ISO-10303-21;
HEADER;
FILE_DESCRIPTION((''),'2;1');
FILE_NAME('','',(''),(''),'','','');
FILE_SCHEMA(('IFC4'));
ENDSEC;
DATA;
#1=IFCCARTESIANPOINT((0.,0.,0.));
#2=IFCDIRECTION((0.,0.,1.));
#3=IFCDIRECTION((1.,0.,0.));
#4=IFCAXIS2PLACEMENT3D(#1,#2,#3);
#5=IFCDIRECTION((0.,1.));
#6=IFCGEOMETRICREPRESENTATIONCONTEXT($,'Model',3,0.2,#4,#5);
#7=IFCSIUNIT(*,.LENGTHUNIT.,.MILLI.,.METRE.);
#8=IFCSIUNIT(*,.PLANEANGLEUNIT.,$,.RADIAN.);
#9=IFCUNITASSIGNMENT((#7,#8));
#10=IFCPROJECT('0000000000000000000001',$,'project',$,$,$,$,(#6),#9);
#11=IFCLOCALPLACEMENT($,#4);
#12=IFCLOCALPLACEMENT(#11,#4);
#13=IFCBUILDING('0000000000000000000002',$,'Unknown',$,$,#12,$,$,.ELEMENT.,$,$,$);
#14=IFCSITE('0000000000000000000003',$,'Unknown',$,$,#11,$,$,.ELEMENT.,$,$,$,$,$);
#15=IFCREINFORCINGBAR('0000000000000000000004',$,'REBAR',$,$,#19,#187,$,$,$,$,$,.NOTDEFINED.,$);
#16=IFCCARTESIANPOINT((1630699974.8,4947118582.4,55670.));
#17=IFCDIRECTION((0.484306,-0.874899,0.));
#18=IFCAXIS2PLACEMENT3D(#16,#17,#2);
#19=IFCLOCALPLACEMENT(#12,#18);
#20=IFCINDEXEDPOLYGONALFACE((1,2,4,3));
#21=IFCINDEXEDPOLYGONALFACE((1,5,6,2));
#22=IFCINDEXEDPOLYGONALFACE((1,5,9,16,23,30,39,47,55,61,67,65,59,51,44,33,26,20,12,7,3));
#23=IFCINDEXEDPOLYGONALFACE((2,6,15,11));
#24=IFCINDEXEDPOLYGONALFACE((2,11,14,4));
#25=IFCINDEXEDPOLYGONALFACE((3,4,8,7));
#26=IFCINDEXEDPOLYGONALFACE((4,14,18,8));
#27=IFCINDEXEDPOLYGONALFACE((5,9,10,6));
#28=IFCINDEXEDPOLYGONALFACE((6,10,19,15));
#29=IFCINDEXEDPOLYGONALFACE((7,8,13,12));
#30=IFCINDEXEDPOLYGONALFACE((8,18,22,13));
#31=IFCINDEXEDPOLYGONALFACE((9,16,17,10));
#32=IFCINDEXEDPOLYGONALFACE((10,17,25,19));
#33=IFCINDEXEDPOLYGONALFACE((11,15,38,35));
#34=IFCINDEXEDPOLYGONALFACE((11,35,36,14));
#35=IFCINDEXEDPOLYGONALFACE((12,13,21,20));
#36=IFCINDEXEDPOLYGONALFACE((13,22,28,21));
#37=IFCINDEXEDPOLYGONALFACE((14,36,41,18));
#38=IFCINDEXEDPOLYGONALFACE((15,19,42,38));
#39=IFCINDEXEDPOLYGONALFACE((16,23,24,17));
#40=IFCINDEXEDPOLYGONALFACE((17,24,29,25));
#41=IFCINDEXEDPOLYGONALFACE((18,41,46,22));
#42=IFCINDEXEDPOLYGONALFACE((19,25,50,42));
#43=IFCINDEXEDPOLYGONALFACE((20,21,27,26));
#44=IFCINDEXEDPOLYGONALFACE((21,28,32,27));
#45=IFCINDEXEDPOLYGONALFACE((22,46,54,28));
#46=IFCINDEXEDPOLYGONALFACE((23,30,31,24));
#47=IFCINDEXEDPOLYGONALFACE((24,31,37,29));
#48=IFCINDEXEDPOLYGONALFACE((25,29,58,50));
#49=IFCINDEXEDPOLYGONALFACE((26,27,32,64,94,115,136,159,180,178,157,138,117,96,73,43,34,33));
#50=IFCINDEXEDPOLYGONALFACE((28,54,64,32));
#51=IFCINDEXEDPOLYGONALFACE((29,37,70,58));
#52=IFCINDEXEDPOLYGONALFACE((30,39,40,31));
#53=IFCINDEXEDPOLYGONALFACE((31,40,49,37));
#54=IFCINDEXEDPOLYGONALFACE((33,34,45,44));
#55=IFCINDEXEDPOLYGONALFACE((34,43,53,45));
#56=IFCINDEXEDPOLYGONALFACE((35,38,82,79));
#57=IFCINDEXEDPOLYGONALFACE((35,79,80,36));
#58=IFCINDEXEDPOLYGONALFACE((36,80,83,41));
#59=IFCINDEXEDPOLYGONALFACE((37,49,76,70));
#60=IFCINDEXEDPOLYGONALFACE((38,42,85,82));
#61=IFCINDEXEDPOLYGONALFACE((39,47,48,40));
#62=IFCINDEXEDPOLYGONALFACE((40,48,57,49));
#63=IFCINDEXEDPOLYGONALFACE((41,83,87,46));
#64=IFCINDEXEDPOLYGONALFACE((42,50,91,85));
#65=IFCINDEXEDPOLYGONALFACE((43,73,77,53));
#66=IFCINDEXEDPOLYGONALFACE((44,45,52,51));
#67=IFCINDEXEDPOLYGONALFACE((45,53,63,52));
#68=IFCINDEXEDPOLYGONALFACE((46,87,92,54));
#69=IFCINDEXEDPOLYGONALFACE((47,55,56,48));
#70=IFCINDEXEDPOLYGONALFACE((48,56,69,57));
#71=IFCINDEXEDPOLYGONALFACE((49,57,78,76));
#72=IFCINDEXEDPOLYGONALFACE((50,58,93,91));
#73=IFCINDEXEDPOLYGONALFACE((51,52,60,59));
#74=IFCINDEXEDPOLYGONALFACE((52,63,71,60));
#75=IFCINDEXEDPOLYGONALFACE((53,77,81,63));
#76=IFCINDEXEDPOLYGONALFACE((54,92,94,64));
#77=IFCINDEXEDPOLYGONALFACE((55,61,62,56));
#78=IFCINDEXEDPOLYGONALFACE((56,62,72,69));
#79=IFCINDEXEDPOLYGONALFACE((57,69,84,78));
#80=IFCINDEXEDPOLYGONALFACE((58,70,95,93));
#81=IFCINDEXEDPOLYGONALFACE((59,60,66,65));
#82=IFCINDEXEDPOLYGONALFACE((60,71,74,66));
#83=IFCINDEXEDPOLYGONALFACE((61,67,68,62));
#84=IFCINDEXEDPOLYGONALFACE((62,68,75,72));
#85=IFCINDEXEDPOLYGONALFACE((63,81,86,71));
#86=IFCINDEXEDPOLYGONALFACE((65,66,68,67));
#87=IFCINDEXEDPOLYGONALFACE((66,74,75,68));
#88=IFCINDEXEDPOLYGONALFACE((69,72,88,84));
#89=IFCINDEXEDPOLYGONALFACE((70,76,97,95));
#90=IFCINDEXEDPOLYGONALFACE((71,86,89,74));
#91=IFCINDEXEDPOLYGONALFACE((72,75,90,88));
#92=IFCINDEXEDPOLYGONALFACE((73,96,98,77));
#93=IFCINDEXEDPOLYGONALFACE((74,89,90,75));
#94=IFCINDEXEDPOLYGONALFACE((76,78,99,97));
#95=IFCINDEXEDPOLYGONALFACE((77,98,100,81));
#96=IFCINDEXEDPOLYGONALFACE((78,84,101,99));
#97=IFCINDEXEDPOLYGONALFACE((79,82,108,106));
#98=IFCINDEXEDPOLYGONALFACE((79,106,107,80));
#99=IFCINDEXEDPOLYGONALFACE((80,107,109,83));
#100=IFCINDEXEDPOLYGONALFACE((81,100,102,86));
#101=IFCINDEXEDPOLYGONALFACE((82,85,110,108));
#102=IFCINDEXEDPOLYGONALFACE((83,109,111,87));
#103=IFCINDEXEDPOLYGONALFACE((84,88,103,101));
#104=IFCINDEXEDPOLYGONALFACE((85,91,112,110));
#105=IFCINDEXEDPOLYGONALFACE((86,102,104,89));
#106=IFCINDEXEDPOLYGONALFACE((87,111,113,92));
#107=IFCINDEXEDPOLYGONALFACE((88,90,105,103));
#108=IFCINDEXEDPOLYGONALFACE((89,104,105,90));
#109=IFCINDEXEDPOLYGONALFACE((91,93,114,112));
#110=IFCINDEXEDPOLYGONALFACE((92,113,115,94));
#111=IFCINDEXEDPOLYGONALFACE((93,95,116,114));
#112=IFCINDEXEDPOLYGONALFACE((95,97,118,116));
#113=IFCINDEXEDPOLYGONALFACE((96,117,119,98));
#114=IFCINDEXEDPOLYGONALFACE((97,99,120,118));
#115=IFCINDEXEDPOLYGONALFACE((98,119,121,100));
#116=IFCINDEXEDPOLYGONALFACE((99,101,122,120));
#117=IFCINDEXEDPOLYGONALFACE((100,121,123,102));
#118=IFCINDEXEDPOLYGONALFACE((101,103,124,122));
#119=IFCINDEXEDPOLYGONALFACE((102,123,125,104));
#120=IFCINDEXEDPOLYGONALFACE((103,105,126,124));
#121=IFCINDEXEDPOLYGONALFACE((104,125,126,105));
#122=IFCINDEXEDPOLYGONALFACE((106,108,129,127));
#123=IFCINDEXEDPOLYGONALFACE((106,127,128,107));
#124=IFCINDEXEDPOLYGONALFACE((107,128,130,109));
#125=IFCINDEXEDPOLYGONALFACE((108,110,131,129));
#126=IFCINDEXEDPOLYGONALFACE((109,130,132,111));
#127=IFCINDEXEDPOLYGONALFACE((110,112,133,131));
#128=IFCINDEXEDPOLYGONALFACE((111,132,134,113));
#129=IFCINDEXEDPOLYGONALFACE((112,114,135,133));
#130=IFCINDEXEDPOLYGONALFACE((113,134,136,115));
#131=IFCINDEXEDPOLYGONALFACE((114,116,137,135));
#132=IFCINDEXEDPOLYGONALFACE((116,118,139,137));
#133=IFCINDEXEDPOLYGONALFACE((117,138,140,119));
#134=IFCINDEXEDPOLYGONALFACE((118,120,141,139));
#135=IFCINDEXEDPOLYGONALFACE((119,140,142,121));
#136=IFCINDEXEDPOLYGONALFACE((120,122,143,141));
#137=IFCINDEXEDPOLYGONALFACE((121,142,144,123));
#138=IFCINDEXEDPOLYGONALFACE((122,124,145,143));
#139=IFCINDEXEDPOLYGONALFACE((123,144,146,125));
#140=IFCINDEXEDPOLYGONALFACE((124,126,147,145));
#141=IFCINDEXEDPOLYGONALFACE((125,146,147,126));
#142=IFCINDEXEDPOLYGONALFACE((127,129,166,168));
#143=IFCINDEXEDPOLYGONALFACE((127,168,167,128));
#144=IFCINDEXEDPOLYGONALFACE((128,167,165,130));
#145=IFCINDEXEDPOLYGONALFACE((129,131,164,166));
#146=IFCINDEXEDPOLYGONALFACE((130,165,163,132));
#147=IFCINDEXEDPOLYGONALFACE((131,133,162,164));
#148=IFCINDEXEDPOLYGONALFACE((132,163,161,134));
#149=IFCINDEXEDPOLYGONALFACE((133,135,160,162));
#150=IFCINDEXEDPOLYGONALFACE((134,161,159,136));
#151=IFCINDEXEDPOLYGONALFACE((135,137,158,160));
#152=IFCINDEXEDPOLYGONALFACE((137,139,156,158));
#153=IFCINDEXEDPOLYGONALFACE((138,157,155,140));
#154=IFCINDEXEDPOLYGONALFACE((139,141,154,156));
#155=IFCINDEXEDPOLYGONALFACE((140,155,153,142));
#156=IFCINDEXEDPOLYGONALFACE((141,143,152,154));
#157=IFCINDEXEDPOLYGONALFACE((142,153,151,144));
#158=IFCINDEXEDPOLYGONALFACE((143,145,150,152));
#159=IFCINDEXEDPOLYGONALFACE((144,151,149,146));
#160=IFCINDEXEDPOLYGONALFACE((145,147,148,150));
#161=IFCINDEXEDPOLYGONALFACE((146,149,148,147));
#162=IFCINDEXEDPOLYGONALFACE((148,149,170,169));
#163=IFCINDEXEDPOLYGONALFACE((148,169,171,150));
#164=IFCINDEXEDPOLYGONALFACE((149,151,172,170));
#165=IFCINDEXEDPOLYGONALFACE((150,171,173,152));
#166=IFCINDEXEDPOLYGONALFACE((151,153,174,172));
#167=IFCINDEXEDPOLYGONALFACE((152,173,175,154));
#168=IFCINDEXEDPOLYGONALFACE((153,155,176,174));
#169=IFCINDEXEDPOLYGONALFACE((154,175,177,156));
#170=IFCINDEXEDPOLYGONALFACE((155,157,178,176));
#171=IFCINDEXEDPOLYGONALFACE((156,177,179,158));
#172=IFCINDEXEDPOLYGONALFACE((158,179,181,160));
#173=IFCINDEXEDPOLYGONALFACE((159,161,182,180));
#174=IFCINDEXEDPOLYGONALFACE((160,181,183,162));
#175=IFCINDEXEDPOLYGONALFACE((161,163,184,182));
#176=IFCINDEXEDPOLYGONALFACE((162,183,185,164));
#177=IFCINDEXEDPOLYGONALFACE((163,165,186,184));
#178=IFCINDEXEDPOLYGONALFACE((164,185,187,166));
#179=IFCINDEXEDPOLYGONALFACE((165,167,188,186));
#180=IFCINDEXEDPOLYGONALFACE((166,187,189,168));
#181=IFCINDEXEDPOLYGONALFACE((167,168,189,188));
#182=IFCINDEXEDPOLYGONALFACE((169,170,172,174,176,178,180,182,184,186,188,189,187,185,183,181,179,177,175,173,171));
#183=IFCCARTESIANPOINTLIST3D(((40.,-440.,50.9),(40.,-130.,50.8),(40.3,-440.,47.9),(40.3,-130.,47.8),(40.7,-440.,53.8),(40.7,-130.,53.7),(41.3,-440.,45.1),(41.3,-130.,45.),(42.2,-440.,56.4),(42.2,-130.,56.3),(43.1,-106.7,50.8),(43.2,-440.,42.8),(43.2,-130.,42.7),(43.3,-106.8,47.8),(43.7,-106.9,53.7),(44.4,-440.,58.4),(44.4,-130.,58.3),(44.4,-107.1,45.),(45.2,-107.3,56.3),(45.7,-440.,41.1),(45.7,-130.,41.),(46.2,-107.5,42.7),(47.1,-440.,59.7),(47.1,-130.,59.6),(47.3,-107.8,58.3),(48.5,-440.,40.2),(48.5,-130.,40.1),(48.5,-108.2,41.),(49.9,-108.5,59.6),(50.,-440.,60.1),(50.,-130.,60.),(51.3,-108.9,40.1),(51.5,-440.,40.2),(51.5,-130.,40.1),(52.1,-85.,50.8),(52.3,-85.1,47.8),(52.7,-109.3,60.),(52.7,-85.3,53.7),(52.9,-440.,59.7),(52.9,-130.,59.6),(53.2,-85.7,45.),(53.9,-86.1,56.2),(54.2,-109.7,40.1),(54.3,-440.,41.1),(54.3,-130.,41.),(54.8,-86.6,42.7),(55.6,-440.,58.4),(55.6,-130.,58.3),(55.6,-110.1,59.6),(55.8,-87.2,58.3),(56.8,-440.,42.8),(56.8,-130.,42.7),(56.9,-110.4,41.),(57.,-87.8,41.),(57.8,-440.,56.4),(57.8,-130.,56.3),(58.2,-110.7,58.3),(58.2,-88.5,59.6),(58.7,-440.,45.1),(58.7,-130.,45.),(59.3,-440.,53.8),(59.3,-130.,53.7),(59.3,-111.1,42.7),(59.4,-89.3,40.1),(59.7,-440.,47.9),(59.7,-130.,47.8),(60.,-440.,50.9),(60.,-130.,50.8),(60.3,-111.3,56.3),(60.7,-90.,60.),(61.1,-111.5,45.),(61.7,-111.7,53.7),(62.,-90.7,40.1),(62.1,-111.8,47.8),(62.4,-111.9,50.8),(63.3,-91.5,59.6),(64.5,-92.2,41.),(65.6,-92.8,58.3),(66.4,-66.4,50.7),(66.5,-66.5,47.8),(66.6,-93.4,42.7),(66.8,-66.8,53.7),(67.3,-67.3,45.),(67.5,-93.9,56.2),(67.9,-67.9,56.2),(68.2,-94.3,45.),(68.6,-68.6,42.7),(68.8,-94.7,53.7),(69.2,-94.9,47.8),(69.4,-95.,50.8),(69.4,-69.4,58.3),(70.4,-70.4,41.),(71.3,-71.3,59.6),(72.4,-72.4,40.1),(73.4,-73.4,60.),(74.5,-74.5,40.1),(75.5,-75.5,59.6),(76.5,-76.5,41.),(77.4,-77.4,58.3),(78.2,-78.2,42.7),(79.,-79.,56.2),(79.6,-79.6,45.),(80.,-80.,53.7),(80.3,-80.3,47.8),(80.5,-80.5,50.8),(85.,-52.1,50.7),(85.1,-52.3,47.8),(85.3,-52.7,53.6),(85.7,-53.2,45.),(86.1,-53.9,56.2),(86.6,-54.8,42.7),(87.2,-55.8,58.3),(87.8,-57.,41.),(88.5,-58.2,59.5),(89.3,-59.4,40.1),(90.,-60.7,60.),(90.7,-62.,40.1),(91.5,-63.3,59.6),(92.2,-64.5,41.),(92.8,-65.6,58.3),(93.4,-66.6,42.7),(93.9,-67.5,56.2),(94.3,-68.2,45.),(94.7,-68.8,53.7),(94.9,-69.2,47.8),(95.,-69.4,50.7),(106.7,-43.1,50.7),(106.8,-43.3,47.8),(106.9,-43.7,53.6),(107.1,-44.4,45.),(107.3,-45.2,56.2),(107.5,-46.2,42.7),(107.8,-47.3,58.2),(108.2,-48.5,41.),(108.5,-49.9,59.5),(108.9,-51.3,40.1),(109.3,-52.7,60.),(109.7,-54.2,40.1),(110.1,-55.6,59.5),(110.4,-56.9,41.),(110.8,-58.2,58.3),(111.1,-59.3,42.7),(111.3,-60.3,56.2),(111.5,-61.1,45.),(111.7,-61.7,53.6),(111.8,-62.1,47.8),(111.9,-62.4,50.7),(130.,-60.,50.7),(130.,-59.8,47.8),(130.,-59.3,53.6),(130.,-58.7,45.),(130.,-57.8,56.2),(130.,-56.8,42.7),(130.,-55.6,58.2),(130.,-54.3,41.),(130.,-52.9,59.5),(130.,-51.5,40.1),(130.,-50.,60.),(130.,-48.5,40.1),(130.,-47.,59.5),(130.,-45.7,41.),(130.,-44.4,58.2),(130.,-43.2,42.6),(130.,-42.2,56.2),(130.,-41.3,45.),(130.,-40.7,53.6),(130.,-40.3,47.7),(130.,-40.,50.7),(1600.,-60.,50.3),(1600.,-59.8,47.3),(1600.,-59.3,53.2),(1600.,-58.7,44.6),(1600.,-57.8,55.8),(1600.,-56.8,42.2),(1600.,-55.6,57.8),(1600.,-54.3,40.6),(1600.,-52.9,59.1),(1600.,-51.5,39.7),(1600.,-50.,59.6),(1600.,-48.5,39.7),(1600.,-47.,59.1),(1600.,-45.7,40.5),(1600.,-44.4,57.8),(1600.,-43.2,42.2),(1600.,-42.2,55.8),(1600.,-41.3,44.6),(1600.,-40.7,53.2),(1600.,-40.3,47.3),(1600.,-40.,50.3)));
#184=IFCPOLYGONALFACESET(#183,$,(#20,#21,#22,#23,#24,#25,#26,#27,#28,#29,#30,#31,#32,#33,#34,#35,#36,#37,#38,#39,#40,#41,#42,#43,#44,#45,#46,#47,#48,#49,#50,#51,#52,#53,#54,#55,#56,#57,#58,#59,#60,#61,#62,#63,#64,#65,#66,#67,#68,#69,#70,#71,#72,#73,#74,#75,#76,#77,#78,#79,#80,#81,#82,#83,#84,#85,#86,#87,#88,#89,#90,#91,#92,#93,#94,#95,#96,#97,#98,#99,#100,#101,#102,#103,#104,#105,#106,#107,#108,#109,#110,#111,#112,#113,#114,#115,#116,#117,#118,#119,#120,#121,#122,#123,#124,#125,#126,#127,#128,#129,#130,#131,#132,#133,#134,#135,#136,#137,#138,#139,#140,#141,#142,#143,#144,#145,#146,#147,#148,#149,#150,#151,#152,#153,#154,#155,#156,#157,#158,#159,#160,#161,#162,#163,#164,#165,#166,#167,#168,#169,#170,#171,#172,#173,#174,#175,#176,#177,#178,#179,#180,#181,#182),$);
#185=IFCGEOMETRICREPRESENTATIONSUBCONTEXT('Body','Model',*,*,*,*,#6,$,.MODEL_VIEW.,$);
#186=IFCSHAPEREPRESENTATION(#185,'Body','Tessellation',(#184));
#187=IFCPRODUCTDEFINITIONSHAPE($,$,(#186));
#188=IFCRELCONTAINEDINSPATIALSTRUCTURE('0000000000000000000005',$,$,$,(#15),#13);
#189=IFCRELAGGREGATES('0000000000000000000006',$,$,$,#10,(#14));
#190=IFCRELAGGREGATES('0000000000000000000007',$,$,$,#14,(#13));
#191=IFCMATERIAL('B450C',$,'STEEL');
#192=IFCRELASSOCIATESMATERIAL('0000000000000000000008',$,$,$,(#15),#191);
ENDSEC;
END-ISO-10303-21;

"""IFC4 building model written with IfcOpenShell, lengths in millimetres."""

from ifc_helpers import new_model, entity, si_unit, direction, frame, origin_with_axes, place, context, subcontext, project, spatial, material, element, save


model = new_model("IFC4")

# Units and contexts
model_context = context("Model", 3, precision=0.2, world=origin_with_axes(), true_north=direction((0.0, 1.0)))
body_context = subcontext(model_context, "Body", "Model", "MODEL_VIEW")
ifc_project = project(units=[si_unit("LENGTHUNIT", "METRE", prefix="MILLI"), si_unit("PLANEANGLEUNIT", "RADIAN")], contexts=[model_context])

# Site, building
site_placement = place(None, origin_with_axes())
site = spatial("IfcSite", under=ifc_project, at=site_placement, Name="Unknown", CompositionType="ELEMENT")
building_placement = place(site_placement, origin_with_axes())
building = spatial("IfcBuilding", under=site, at=building_placement, Name="Unknown", CompositionType="ELEMENT")

# Reinforcing bar
ifc_material = material(Name="B450C", Category="STEEL")
reinforcing_bar_1_placement = place(building_placement, frame((1630699974.8, 4947118582.4, 55670.0), z_axis=(0.484306, -0.874899, 0.0), x_axis=(0.0, 0.0, 1.0)))
element("IfcReinforcingBar", 1, at=reinforcing_bar_1_placement, inside=building, material=ifc_material, Name="REBAR", PredefinedType="NOTDEFINED", context=body_context, shape_type="AdvancedSweptSolid", body=[
    entity("IfcSweptDiskSolid", entity("IfcIndexedPolyCurve", entity("IfcCartesianPointList3D", [[50.0, -440.0, 50.1], [50.0, -130.0, 50.0], [73.4, -73.4, 50.0], [130.0, -50.0, 50.0], [1600.0, -50.0, 49.6]]), [entity("IfcLineIndex", [1, 2]), entity("IfcArcIndex", [2, 3, 4]), entity("IfcLineIndex", [4, 5])]), 10.0),
])

save(model, "model.ifc")
